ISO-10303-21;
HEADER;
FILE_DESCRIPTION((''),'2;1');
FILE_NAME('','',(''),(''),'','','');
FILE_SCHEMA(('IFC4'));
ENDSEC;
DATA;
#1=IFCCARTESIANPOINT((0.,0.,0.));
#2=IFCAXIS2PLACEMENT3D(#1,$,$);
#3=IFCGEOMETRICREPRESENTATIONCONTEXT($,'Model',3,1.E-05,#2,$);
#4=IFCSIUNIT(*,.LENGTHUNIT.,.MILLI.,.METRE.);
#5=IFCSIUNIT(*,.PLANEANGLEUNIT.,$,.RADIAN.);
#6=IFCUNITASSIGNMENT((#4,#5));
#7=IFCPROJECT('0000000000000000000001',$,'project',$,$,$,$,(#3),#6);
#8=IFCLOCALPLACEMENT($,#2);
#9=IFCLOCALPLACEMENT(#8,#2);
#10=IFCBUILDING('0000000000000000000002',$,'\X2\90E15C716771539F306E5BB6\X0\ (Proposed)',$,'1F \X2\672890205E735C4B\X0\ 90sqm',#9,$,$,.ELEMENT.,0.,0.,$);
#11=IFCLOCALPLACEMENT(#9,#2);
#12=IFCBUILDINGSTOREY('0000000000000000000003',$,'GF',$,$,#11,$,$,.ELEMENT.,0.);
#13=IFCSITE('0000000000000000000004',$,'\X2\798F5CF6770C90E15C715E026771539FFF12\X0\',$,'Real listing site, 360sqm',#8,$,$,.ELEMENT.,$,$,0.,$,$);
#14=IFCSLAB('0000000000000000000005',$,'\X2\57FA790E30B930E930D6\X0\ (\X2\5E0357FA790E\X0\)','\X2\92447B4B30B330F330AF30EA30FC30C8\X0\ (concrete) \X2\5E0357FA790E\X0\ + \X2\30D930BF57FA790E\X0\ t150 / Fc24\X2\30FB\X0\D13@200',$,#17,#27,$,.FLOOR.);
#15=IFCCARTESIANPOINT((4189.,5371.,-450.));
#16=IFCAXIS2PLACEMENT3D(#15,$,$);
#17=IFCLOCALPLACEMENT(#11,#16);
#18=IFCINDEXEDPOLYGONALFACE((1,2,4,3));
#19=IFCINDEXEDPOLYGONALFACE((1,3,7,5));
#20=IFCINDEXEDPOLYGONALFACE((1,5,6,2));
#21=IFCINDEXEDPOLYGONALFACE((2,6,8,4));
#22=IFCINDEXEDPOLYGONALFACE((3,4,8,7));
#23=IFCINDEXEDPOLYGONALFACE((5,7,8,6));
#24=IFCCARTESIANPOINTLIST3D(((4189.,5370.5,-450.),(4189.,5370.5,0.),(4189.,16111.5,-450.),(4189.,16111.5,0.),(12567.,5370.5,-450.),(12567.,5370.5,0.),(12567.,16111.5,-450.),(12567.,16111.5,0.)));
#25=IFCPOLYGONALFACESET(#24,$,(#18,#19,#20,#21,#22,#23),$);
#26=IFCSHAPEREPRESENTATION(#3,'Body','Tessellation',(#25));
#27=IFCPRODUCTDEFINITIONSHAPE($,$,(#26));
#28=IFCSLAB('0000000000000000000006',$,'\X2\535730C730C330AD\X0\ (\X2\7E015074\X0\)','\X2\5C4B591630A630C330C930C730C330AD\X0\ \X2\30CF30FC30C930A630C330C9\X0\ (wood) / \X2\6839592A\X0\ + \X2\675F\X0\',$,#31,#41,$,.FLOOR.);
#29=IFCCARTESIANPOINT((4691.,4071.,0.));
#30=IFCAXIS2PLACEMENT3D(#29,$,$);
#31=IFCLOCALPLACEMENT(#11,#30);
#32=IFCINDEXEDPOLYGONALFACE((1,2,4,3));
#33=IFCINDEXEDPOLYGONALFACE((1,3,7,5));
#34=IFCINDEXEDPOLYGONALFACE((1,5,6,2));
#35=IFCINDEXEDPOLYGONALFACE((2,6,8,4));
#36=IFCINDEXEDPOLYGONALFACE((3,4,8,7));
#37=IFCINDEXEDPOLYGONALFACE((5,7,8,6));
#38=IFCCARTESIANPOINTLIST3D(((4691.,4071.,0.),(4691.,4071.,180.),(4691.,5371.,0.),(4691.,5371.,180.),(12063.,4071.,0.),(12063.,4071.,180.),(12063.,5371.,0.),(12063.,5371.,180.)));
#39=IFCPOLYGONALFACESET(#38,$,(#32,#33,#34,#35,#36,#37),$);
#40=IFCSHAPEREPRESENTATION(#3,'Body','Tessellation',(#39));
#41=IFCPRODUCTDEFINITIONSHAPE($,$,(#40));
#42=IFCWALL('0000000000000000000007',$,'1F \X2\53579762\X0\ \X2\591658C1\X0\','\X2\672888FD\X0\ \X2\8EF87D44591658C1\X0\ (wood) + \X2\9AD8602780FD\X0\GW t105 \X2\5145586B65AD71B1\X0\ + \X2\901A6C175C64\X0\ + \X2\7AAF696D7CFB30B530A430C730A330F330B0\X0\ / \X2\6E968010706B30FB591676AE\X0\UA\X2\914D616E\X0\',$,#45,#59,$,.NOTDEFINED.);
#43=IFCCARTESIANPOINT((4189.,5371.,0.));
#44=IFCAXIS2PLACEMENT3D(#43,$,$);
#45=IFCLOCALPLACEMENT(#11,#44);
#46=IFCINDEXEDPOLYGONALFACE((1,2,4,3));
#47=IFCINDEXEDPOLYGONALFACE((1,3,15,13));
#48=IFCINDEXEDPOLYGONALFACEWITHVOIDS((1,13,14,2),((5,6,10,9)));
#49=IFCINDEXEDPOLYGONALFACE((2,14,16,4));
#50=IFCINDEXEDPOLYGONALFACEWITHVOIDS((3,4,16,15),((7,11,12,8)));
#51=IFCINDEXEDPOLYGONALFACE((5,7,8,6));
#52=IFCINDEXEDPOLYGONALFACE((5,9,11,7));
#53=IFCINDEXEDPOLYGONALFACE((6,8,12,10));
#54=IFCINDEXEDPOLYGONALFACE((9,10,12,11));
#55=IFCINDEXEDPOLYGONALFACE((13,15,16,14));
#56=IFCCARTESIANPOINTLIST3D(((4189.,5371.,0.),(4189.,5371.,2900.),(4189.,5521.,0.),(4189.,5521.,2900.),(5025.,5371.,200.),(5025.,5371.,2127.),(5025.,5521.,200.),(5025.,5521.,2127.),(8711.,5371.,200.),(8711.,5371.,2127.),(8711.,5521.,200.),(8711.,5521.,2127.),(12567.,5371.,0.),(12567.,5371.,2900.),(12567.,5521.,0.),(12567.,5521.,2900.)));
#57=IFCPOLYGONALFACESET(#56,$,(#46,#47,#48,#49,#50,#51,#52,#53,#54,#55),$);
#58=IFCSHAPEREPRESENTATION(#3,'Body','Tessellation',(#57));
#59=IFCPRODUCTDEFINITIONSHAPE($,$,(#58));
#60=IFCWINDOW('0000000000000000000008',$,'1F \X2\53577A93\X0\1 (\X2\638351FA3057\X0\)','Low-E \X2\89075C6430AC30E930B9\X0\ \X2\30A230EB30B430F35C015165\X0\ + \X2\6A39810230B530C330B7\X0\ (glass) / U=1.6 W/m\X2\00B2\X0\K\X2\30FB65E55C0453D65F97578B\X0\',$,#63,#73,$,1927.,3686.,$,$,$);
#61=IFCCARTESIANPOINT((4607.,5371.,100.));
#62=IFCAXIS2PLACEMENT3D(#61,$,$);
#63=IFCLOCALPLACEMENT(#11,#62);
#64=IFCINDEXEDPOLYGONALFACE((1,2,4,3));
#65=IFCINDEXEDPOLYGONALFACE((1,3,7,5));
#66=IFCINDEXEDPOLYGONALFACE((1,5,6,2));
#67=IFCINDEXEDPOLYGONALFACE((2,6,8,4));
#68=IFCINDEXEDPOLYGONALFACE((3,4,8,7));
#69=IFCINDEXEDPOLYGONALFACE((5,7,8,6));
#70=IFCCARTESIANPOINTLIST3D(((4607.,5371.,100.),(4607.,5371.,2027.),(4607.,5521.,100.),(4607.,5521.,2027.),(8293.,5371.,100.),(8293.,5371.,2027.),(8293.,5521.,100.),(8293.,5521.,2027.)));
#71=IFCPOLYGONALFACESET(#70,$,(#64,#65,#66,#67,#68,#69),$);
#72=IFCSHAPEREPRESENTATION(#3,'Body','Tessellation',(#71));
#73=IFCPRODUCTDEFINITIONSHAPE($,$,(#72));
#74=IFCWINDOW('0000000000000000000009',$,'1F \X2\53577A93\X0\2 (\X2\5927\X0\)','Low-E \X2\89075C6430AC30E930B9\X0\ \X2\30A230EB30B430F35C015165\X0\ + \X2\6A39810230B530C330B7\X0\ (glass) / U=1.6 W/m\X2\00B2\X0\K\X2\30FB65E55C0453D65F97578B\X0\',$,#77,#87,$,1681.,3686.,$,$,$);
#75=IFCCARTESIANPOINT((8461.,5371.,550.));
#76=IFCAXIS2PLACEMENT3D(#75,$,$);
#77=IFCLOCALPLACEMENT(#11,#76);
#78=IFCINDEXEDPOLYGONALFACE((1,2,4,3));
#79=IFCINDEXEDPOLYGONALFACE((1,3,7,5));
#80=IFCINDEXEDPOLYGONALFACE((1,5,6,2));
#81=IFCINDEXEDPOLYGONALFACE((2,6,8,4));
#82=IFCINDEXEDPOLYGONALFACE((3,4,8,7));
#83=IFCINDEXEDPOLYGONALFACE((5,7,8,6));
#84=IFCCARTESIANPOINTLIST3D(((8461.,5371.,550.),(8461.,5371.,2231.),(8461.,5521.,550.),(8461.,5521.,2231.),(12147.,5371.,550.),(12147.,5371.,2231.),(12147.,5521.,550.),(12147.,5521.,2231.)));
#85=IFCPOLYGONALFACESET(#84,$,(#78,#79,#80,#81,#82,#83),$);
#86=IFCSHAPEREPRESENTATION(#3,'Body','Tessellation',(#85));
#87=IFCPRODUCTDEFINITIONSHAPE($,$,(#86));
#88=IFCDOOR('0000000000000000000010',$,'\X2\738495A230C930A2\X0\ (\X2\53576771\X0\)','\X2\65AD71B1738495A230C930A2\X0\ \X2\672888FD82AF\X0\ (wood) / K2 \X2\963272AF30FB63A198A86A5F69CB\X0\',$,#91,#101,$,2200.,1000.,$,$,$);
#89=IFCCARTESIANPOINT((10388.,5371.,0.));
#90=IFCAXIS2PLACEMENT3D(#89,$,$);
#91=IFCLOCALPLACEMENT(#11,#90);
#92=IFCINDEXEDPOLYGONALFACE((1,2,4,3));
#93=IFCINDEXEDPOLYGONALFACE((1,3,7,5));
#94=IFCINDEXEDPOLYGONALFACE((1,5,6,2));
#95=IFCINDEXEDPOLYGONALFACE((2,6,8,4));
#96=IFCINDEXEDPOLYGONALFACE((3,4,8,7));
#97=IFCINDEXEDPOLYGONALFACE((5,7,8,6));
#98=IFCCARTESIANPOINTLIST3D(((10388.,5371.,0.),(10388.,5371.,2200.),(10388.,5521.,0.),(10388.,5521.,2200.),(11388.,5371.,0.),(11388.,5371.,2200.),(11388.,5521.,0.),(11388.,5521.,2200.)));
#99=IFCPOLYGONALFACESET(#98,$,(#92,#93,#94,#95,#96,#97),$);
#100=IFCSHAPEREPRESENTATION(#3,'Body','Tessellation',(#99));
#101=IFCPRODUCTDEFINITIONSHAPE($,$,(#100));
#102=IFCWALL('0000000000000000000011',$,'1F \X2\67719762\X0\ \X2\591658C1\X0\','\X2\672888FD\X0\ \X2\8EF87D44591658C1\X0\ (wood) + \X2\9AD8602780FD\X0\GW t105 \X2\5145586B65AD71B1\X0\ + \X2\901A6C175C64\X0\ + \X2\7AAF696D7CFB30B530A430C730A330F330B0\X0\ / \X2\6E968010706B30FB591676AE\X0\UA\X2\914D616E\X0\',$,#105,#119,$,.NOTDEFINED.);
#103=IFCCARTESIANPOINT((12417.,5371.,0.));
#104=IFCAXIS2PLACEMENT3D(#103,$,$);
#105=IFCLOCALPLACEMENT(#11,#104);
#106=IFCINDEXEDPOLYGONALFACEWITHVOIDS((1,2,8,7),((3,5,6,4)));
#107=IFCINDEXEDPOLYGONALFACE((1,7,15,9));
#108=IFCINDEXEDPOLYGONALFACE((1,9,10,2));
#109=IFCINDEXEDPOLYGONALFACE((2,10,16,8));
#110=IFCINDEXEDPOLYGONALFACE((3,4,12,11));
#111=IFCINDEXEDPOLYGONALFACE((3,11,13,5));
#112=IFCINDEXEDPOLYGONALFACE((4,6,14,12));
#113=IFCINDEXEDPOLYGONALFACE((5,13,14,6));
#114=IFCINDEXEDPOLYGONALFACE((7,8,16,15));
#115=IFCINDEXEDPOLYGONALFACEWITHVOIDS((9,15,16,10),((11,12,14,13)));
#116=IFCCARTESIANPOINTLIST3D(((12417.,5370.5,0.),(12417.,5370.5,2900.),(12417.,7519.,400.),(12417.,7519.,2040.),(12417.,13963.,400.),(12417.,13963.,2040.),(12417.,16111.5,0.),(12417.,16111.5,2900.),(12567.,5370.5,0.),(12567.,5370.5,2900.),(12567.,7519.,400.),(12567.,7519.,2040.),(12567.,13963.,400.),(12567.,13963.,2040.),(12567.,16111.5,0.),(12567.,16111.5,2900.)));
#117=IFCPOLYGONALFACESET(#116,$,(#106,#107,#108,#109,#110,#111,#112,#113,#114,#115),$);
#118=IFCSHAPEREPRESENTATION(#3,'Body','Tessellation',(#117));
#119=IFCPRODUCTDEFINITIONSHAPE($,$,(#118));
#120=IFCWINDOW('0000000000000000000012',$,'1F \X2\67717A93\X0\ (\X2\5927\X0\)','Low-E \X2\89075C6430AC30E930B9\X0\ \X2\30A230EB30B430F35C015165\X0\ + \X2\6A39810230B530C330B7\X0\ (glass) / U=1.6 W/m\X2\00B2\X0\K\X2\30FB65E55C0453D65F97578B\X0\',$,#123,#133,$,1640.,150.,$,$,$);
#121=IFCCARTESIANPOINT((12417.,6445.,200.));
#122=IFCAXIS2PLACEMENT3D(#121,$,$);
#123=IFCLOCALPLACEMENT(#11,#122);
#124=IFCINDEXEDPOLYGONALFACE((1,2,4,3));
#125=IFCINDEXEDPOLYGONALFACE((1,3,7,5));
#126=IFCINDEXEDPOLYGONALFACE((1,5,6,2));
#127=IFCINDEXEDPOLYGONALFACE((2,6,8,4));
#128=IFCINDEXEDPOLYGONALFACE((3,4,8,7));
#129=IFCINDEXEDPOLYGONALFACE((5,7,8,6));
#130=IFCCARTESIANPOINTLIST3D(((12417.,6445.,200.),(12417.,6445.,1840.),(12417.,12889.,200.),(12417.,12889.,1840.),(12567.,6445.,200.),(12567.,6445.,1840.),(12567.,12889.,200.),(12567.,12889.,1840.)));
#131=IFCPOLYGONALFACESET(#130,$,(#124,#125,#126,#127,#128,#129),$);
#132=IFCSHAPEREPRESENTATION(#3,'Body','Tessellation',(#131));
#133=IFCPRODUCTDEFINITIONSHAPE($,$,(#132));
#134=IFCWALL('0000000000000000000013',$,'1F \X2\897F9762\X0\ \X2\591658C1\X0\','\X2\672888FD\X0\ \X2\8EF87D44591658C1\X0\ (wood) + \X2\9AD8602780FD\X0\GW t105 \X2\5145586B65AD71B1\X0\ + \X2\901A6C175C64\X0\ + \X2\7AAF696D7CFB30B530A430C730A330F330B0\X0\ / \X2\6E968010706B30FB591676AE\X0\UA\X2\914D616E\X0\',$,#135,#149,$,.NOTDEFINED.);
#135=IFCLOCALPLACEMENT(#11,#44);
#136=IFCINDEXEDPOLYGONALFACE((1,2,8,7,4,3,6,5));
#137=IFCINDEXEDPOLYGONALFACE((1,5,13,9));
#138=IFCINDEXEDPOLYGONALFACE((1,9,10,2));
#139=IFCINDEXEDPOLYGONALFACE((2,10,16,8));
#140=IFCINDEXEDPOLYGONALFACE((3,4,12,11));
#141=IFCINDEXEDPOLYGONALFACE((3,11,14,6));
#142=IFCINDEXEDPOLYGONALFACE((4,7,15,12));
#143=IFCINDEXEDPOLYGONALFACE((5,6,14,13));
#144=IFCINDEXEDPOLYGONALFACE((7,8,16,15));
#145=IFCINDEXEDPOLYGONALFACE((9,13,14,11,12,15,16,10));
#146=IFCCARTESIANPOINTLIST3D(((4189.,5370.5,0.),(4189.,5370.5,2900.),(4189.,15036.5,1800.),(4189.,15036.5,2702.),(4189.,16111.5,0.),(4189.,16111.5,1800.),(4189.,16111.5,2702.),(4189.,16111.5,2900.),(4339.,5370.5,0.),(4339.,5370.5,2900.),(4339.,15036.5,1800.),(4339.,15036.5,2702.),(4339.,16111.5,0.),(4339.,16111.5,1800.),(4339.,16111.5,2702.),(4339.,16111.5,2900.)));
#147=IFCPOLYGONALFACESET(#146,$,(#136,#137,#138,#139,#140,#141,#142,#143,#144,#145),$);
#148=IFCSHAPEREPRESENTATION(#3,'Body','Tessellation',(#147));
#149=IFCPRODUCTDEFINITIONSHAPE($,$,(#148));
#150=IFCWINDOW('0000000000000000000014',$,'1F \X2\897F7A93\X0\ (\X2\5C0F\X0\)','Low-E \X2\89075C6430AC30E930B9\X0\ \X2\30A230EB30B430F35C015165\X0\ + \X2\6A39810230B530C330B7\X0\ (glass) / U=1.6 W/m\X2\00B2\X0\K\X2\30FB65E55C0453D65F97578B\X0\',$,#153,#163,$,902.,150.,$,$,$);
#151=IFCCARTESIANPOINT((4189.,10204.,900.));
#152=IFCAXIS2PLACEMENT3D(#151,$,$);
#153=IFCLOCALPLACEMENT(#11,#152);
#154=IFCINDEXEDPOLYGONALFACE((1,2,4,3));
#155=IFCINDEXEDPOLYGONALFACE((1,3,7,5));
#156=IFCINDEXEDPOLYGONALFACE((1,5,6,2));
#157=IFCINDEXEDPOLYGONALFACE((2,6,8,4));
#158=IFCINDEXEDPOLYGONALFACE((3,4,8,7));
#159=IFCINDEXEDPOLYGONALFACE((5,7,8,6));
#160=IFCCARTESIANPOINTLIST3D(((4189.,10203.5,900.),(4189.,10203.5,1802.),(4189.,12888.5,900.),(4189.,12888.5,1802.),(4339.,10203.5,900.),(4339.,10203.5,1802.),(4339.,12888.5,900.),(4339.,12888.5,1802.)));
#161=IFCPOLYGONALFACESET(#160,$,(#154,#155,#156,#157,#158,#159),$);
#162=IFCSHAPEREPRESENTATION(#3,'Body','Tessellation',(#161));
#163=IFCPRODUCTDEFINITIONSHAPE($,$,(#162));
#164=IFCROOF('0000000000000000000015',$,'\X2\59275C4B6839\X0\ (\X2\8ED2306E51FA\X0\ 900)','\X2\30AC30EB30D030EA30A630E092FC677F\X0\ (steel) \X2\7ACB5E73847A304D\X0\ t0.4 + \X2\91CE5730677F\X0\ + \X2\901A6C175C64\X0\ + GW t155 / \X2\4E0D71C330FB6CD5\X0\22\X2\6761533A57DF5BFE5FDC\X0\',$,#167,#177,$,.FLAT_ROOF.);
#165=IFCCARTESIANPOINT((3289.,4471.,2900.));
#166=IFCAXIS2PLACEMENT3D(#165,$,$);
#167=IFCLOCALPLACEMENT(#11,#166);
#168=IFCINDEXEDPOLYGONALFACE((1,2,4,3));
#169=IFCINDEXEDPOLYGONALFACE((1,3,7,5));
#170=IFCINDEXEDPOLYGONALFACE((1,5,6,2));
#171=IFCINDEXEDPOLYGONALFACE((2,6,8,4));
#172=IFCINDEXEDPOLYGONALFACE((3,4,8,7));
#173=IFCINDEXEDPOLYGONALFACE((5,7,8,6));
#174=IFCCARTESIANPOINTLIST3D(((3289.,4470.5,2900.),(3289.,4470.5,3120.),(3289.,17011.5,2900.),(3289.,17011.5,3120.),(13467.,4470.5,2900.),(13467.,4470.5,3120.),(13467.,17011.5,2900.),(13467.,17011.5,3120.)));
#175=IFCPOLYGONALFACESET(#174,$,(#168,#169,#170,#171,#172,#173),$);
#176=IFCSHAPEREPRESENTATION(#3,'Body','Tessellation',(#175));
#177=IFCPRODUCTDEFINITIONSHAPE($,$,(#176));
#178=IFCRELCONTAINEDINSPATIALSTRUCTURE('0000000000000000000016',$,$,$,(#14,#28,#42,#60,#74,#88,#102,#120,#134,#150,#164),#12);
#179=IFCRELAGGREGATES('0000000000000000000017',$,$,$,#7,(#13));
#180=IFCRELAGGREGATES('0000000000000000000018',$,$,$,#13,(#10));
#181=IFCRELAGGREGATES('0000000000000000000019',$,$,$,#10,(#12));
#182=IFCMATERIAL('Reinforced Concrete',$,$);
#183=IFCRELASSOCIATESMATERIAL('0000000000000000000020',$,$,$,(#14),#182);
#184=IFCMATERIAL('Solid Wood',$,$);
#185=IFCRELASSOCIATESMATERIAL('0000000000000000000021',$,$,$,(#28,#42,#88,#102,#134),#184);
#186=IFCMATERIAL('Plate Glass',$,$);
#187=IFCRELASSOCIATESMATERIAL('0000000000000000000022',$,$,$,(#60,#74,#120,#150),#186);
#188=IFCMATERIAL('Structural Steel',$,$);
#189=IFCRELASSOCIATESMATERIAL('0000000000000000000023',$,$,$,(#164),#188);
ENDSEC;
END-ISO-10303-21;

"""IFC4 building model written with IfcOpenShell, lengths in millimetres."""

from ifc_helpers import new_model, si_unit, frame, frame_2d, origin, place, context, project, spatial, rectangle, extrude, material, element, fill, save


model = new_model("IFC4")

# Units and contexts
model_context = context("Model", 3, precision=1e-05, world=origin())
ifc_project = project(units=[si_unit("LENGTHUNIT", "METRE", prefix="MILLI"), si_unit("PLANEANGLEUNIT", "RADIAN")], contexts=[model_context])

# Site, building, storey
site_placement = place(None, origin())
site = spatial("IfcSite", under=ifc_project, at=site_placement, Name="福島県郡山市東原２", ObjectType="Real listing site, 360sqm", CompositionType="ELEMENT", RefElevation=0.0)
building_placement = place(site_placement, origin())
building = spatial("IfcBuilding", under=site, at=building_placement, Name="郡山東原の家 (Proposed)", ObjectType="1F 木造平屋 90sqm", CompositionType="ELEMENT", ElevationOfRefHeight=0.0, ElevationOfTerrain=0.0)
storey_placement = place(building_placement, origin())
storey = spatial("IfcBuildingStorey", under=building, at=storey_placement, Name="GF", CompositionType="ELEMENT", Elevation=0.0)

# Slabs
ifc_material_1 = material(Name="Reinforced Concrete")
slab_1_placement = place(storey_placement, frame((4189.0, 5371.0, -450.0)))
element("IfcSlab", 1, at=slab_1_placement, inside=storey, material=ifc_material_1, Name="基礎スラブ (布基礎)", Description="鉄筋コンクリート (concrete) 布基礎 + ベタ基礎 t150 / Fc24・D13@200", PredefinedType="FLOOR", context=model_context, shape_type="SweptSolid", body=[
    extrude(rectangle(XDim=8378.0, YDim=10741.0, at=frame_2d((4189.0, 5370.0))), frame((4189.0, 5371.0, -450.0)), (0.0, 0.0, 1.0), 450.0),
])
ifc_material_2 = material(Name="Solid Wood")
slab_2_placement = place(storey_placement, frame((4691.0, 4071.0, 0.0)))
element("IfcSlab", 2, at=slab_2_placement, inside=storey, material=ifc_material_2, Name="南デッキ (縁側)", Description="屋外ウッドデッキ ハードウッド (wood) / 根太 + 束", PredefinedType="FLOOR", context=model_context, shape_type="SweptSolid", body=[
    extrude(rectangle(XDim=7372.0, YDim=1300.0, at=frame_2d((3686.0, 650.0))), frame((4691.0, 4071.0, 0.0)), (0.0, 0.0, 1.0), 180.0),
])

# Wall, openings, windows, door
wall_1_placement = place(storey_placement, frame((4189.0, 5371.0, 0.0)))
wall_1 = element("IfcWall", 3, at=wall_1_placement, inside=storey, material=ifc_material_2, Name="1F 南面 外壁", Description="木製 軸組外壁 (wood) + 高性能GW t105 充填断熱 + 通気層 + 窯業系サイディング / 準耐火・外皮UA配慮", PredefinedType="NOTDEFINED", context=model_context, shape_type="SweptSolid", body=[
    extrude(rectangle(XDim=8378.0, YDim=150.0, at=frame_2d((4189.0, 75.0))), frame((4189.0, 5371.0, 0.0)), (0.0, 0.0, 1.0), 2900.0),
])
opening_1_placement = place(storey_placement, frame((4607.0, 5371.0, 100.0)))
opening_1 = element("IfcOpeningElement", 4, at=opening_1_placement, cuts=wall_1, PredefinedType="NOTDEFINED", context=model_context, shape_type="SweptSolid", body=[
    extrude(rectangle(XDim=3686.0, YDim=150.0, at=frame_2d((1843.0, 75.0))), frame((4607.0, 5371.0, 100.0)), (0.0, 0.0, 1.0), 1927.0),
])
opening_2_placement = place(storey_placement, frame((8461.0, 5371.0, 550.0)))
opening_2 = element("IfcOpeningElement", 5, at=opening_2_placement, cuts=wall_1, PredefinedType="NOTDEFINED", context=model_context, shape_type="SweptSolid", body=[
    extrude(rectangle(XDim=3686.0, YDim=150.0, at=frame_2d((1843.0, 75.0))), frame((8461.0, 5371.0, 550.0)), (0.0, 0.0, 1.0), 1681.0),
])
opening_3_placement = place(storey_placement, frame((10388.0, 5371.0, 0.0)))
opening_3 = element("IfcOpeningElement", 6, at=opening_3_placement, cuts=wall_1, PredefinedType="NOTDEFINED", context=model_context, shape_type="SweptSolid", body=[
    extrude(rectangle(XDim=1000.0, YDim=150.0, at=frame_2d((500.0, 75.0))), frame((10388.0, 5371.0, 0.0)), (0.0, 0.0, 1.0), 2200.0),
])
ifc_material_3 = material(Name="Plate Glass")
window_1_placement = place(storey_placement, frame((4607.0, 5371.0, 100.0)))
window_1 = element("IfcWindow", 7, at=window_1_placement, inside=storey, material=ifc_material_3, Name="1F 南窓1 (掃出し)", Description="Low-E 複層ガラス アルゴン封入 + 樹脂サッシ (glass) / U=1.6 W/m²K・日射取得型", OverallHeight=1927.0, OverallWidth=3686.0, context=model_context, shape_type="SweptSolid", body=[
    extrude(rectangle(XDim=3686.0, YDim=150.0, at=frame_2d((1843.0, 75.0))), frame((4607.0, 5371.0, 100.0)), (0.0, 0.0, 1.0), 1927.0),
])
fill(opening_1, window_1)
window_2_placement = place(storey_placement, frame((8461.0, 5371.0, 550.0)))
window_2 = element("IfcWindow", 8, at=window_2_placement, inside=storey, material=ifc_material_3, Name="1F 南窓2 (大)", Description="Low-E 複層ガラス アルゴン封入 + 樹脂サッシ (glass) / U=1.6 W/m²K・日射取得型", OverallHeight=1681.0, OverallWidth=3686.0, context=model_context, shape_type="SweptSolid", body=[
    extrude(rectangle(XDim=3686.0, YDim=150.0, at=frame_2d((1843.0, 75.0))), frame((8461.0, 5371.0, 550.0)), (0.0, 0.0, 1.0), 1681.0),
])
fill(opening_2, window_2)
door_placement = place(storey_placement, frame((10388.0, 5371.0, 0.0)))
door = element("IfcDoor", 9, at=door_placement, inside=storey, material=ifc_material_2, Name="玄関ドア (南東)", Description="断熱玄関ドア 木製芯 (wood) / K2 防犯・採風機構", OverallHeight=2200.0, OverallWidth=1000.0, context=model_context, shape_type="SweptSolid", body=[
    extrude(rectangle(XDim=1000.0, YDim=150.0, at=frame_2d((500.0, 75.0))), frame((10388.0, 5371.0, 0.0)), (0.0, 0.0, 1.0), 2200.0),
])
fill(opening_3, door)

# Walls, openings, windows
wall_2_placement = place(storey_placement, frame((12417.0, 5371.0, 0.0)))
wall_2 = element("IfcWall", 10, at=wall_2_placement, inside=storey, material=ifc_material_2, Name="1F 東面 外壁", Description="木製 軸組外壁 (wood) + 高性能GW t105 充填断熱 + 通気層 + 窯業系サイディング / 準耐火・外皮UA配慮", PredefinedType="NOTDEFINED", context=model_context, shape_type="SweptSolid", body=[
    extrude(rectangle(XDim=150.0, YDim=10741.0, at=frame_2d((75.0, 5370.0))), frame((12417.0, 5371.0, 0.0)), (0.0, 0.0, 1.0), 2900.0),
])
opening_4_placement = place(storey_placement, frame((12417.0, 6445.0, 200.0)))
opening_4 = element("IfcOpeningElement", 11, at=opening_4_placement, cuts=wall_2, PredefinedType="NOTDEFINED", context=model_context, shape_type="SweptSolid", body=[
    extrude(rectangle(XDim=150.0, YDim=6444.0, at=frame_2d((75.0, 3222.0))), frame((12417.0, 6445.0, 200.0)), (0.0, 0.0, 1.0), 1640.0),
])
window_3_placement = place(storey_placement, frame((12417.0, 6445.0, 200.0)))
window_3 = element("IfcWindow", 12, at=window_3_placement, inside=storey, material=ifc_material_3, Name="1F 東窓 (大)", Description="Low-E 複層ガラス アルゴン封入 + 樹脂サッシ (glass) / U=1.6 W/m²K・日射取得型", OverallHeight=1640.0, OverallWidth=150.0, context=model_context, shape_type="SweptSolid", body=[
    extrude(rectangle(XDim=150.0, YDim=6444.0, at=frame_2d((75.0, 3222.0))), frame((12417.0, 6445.0, 200.0)), (0.0, 0.0, 1.0), 1640.0),
])
fill(opening_4, window_3)
wall_3_placement = place(storey_placement, frame((4189.0, 5371.0, 0.0)))
wall_3 = element("IfcWall", 13, at=wall_3_placement, inside=storey, material=ifc_material_2, Name="1F 西面 外壁", Description="木製 軸組外壁 (wood) + 高性能GW t105 充填断熱 + 通気層 + 窯業系サイディング / 準耐火・外皮UA配慮", PredefinedType="NOTDEFINED", context=model_context, shape_type="SweptSolid", body=[
    extrude(rectangle(XDim=150.0, YDim=10741.0, at=frame_2d((75.0, 5370.0))), frame((4189.0, 5371.0, 0.0)), (0.0, 0.0, 1.0), 2900.0),
])
opening_5_placement = place(storey_placement, frame((4189.0, 10204.0, 900.0)))
opening_5 = element("IfcOpeningElement", 14, at=opening_5_placement, cuts=wall_3, PredefinedType="NOTDEFINED", context=model_context, shape_type="SweptSolid", body=[
    extrude(rectangle(XDim=150.0, YDim=2685.0, at=frame_2d((75.0, 1342.0))), frame((4189.0, 10204.0, 900.0)), (0.0, 0.0, 1.0), 902.0),
])
window_4_placement = place(storey_placement, frame((4189.0, 10204.0, 900.0)))
window_4 = element("IfcWindow", 15, at=window_4_placement, inside=storey, material=ifc_material_3, Name="1F 西窓 (小)", Description="Low-E 複層ガラス アルゴン封入 + 樹脂サッシ (glass) / U=1.6 W/m²K・日射取得型", OverallHeight=902.0, OverallWidth=150.0, context=model_context, shape_type="SweptSolid", body=[
    extrude(rectangle(XDim=150.0, YDim=2685.0, at=frame_2d((75.0, 1342.0))), frame((4189.0, 10204.0, 900.0)), (0.0, 0.0, 1.0), 902.0),
])
fill(opening_5, window_4)

# Roof
ifc_material_4 = material(Name="Structural Steel")
roof_placement = place(storey_placement, frame((3289.0, 4471.0, 2900.0)))
element("IfcRoof", 16, at=roof_placement, inside=storey, material=ifc_material_4, Name="大屋根 (軒の出 900)", Description="ガルバリウム鋼板 (steel) 立平葺き t0.4 + 野地板 + 通気層 + GW t155 / 不燃・法22条区域対応", PredefinedType="FLAT_ROOF", context=model_context, shape_type="SweptSolid", body=[
    extrude(rectangle(XDim=10178.0, YDim=12541.0, at=frame_2d((5089.0, 6270.0))), frame((3289.0, 4471.0, 2900.0)), (0.0, 0.0, 1.0), 220.0),
])

save(model, "model.ifc")
